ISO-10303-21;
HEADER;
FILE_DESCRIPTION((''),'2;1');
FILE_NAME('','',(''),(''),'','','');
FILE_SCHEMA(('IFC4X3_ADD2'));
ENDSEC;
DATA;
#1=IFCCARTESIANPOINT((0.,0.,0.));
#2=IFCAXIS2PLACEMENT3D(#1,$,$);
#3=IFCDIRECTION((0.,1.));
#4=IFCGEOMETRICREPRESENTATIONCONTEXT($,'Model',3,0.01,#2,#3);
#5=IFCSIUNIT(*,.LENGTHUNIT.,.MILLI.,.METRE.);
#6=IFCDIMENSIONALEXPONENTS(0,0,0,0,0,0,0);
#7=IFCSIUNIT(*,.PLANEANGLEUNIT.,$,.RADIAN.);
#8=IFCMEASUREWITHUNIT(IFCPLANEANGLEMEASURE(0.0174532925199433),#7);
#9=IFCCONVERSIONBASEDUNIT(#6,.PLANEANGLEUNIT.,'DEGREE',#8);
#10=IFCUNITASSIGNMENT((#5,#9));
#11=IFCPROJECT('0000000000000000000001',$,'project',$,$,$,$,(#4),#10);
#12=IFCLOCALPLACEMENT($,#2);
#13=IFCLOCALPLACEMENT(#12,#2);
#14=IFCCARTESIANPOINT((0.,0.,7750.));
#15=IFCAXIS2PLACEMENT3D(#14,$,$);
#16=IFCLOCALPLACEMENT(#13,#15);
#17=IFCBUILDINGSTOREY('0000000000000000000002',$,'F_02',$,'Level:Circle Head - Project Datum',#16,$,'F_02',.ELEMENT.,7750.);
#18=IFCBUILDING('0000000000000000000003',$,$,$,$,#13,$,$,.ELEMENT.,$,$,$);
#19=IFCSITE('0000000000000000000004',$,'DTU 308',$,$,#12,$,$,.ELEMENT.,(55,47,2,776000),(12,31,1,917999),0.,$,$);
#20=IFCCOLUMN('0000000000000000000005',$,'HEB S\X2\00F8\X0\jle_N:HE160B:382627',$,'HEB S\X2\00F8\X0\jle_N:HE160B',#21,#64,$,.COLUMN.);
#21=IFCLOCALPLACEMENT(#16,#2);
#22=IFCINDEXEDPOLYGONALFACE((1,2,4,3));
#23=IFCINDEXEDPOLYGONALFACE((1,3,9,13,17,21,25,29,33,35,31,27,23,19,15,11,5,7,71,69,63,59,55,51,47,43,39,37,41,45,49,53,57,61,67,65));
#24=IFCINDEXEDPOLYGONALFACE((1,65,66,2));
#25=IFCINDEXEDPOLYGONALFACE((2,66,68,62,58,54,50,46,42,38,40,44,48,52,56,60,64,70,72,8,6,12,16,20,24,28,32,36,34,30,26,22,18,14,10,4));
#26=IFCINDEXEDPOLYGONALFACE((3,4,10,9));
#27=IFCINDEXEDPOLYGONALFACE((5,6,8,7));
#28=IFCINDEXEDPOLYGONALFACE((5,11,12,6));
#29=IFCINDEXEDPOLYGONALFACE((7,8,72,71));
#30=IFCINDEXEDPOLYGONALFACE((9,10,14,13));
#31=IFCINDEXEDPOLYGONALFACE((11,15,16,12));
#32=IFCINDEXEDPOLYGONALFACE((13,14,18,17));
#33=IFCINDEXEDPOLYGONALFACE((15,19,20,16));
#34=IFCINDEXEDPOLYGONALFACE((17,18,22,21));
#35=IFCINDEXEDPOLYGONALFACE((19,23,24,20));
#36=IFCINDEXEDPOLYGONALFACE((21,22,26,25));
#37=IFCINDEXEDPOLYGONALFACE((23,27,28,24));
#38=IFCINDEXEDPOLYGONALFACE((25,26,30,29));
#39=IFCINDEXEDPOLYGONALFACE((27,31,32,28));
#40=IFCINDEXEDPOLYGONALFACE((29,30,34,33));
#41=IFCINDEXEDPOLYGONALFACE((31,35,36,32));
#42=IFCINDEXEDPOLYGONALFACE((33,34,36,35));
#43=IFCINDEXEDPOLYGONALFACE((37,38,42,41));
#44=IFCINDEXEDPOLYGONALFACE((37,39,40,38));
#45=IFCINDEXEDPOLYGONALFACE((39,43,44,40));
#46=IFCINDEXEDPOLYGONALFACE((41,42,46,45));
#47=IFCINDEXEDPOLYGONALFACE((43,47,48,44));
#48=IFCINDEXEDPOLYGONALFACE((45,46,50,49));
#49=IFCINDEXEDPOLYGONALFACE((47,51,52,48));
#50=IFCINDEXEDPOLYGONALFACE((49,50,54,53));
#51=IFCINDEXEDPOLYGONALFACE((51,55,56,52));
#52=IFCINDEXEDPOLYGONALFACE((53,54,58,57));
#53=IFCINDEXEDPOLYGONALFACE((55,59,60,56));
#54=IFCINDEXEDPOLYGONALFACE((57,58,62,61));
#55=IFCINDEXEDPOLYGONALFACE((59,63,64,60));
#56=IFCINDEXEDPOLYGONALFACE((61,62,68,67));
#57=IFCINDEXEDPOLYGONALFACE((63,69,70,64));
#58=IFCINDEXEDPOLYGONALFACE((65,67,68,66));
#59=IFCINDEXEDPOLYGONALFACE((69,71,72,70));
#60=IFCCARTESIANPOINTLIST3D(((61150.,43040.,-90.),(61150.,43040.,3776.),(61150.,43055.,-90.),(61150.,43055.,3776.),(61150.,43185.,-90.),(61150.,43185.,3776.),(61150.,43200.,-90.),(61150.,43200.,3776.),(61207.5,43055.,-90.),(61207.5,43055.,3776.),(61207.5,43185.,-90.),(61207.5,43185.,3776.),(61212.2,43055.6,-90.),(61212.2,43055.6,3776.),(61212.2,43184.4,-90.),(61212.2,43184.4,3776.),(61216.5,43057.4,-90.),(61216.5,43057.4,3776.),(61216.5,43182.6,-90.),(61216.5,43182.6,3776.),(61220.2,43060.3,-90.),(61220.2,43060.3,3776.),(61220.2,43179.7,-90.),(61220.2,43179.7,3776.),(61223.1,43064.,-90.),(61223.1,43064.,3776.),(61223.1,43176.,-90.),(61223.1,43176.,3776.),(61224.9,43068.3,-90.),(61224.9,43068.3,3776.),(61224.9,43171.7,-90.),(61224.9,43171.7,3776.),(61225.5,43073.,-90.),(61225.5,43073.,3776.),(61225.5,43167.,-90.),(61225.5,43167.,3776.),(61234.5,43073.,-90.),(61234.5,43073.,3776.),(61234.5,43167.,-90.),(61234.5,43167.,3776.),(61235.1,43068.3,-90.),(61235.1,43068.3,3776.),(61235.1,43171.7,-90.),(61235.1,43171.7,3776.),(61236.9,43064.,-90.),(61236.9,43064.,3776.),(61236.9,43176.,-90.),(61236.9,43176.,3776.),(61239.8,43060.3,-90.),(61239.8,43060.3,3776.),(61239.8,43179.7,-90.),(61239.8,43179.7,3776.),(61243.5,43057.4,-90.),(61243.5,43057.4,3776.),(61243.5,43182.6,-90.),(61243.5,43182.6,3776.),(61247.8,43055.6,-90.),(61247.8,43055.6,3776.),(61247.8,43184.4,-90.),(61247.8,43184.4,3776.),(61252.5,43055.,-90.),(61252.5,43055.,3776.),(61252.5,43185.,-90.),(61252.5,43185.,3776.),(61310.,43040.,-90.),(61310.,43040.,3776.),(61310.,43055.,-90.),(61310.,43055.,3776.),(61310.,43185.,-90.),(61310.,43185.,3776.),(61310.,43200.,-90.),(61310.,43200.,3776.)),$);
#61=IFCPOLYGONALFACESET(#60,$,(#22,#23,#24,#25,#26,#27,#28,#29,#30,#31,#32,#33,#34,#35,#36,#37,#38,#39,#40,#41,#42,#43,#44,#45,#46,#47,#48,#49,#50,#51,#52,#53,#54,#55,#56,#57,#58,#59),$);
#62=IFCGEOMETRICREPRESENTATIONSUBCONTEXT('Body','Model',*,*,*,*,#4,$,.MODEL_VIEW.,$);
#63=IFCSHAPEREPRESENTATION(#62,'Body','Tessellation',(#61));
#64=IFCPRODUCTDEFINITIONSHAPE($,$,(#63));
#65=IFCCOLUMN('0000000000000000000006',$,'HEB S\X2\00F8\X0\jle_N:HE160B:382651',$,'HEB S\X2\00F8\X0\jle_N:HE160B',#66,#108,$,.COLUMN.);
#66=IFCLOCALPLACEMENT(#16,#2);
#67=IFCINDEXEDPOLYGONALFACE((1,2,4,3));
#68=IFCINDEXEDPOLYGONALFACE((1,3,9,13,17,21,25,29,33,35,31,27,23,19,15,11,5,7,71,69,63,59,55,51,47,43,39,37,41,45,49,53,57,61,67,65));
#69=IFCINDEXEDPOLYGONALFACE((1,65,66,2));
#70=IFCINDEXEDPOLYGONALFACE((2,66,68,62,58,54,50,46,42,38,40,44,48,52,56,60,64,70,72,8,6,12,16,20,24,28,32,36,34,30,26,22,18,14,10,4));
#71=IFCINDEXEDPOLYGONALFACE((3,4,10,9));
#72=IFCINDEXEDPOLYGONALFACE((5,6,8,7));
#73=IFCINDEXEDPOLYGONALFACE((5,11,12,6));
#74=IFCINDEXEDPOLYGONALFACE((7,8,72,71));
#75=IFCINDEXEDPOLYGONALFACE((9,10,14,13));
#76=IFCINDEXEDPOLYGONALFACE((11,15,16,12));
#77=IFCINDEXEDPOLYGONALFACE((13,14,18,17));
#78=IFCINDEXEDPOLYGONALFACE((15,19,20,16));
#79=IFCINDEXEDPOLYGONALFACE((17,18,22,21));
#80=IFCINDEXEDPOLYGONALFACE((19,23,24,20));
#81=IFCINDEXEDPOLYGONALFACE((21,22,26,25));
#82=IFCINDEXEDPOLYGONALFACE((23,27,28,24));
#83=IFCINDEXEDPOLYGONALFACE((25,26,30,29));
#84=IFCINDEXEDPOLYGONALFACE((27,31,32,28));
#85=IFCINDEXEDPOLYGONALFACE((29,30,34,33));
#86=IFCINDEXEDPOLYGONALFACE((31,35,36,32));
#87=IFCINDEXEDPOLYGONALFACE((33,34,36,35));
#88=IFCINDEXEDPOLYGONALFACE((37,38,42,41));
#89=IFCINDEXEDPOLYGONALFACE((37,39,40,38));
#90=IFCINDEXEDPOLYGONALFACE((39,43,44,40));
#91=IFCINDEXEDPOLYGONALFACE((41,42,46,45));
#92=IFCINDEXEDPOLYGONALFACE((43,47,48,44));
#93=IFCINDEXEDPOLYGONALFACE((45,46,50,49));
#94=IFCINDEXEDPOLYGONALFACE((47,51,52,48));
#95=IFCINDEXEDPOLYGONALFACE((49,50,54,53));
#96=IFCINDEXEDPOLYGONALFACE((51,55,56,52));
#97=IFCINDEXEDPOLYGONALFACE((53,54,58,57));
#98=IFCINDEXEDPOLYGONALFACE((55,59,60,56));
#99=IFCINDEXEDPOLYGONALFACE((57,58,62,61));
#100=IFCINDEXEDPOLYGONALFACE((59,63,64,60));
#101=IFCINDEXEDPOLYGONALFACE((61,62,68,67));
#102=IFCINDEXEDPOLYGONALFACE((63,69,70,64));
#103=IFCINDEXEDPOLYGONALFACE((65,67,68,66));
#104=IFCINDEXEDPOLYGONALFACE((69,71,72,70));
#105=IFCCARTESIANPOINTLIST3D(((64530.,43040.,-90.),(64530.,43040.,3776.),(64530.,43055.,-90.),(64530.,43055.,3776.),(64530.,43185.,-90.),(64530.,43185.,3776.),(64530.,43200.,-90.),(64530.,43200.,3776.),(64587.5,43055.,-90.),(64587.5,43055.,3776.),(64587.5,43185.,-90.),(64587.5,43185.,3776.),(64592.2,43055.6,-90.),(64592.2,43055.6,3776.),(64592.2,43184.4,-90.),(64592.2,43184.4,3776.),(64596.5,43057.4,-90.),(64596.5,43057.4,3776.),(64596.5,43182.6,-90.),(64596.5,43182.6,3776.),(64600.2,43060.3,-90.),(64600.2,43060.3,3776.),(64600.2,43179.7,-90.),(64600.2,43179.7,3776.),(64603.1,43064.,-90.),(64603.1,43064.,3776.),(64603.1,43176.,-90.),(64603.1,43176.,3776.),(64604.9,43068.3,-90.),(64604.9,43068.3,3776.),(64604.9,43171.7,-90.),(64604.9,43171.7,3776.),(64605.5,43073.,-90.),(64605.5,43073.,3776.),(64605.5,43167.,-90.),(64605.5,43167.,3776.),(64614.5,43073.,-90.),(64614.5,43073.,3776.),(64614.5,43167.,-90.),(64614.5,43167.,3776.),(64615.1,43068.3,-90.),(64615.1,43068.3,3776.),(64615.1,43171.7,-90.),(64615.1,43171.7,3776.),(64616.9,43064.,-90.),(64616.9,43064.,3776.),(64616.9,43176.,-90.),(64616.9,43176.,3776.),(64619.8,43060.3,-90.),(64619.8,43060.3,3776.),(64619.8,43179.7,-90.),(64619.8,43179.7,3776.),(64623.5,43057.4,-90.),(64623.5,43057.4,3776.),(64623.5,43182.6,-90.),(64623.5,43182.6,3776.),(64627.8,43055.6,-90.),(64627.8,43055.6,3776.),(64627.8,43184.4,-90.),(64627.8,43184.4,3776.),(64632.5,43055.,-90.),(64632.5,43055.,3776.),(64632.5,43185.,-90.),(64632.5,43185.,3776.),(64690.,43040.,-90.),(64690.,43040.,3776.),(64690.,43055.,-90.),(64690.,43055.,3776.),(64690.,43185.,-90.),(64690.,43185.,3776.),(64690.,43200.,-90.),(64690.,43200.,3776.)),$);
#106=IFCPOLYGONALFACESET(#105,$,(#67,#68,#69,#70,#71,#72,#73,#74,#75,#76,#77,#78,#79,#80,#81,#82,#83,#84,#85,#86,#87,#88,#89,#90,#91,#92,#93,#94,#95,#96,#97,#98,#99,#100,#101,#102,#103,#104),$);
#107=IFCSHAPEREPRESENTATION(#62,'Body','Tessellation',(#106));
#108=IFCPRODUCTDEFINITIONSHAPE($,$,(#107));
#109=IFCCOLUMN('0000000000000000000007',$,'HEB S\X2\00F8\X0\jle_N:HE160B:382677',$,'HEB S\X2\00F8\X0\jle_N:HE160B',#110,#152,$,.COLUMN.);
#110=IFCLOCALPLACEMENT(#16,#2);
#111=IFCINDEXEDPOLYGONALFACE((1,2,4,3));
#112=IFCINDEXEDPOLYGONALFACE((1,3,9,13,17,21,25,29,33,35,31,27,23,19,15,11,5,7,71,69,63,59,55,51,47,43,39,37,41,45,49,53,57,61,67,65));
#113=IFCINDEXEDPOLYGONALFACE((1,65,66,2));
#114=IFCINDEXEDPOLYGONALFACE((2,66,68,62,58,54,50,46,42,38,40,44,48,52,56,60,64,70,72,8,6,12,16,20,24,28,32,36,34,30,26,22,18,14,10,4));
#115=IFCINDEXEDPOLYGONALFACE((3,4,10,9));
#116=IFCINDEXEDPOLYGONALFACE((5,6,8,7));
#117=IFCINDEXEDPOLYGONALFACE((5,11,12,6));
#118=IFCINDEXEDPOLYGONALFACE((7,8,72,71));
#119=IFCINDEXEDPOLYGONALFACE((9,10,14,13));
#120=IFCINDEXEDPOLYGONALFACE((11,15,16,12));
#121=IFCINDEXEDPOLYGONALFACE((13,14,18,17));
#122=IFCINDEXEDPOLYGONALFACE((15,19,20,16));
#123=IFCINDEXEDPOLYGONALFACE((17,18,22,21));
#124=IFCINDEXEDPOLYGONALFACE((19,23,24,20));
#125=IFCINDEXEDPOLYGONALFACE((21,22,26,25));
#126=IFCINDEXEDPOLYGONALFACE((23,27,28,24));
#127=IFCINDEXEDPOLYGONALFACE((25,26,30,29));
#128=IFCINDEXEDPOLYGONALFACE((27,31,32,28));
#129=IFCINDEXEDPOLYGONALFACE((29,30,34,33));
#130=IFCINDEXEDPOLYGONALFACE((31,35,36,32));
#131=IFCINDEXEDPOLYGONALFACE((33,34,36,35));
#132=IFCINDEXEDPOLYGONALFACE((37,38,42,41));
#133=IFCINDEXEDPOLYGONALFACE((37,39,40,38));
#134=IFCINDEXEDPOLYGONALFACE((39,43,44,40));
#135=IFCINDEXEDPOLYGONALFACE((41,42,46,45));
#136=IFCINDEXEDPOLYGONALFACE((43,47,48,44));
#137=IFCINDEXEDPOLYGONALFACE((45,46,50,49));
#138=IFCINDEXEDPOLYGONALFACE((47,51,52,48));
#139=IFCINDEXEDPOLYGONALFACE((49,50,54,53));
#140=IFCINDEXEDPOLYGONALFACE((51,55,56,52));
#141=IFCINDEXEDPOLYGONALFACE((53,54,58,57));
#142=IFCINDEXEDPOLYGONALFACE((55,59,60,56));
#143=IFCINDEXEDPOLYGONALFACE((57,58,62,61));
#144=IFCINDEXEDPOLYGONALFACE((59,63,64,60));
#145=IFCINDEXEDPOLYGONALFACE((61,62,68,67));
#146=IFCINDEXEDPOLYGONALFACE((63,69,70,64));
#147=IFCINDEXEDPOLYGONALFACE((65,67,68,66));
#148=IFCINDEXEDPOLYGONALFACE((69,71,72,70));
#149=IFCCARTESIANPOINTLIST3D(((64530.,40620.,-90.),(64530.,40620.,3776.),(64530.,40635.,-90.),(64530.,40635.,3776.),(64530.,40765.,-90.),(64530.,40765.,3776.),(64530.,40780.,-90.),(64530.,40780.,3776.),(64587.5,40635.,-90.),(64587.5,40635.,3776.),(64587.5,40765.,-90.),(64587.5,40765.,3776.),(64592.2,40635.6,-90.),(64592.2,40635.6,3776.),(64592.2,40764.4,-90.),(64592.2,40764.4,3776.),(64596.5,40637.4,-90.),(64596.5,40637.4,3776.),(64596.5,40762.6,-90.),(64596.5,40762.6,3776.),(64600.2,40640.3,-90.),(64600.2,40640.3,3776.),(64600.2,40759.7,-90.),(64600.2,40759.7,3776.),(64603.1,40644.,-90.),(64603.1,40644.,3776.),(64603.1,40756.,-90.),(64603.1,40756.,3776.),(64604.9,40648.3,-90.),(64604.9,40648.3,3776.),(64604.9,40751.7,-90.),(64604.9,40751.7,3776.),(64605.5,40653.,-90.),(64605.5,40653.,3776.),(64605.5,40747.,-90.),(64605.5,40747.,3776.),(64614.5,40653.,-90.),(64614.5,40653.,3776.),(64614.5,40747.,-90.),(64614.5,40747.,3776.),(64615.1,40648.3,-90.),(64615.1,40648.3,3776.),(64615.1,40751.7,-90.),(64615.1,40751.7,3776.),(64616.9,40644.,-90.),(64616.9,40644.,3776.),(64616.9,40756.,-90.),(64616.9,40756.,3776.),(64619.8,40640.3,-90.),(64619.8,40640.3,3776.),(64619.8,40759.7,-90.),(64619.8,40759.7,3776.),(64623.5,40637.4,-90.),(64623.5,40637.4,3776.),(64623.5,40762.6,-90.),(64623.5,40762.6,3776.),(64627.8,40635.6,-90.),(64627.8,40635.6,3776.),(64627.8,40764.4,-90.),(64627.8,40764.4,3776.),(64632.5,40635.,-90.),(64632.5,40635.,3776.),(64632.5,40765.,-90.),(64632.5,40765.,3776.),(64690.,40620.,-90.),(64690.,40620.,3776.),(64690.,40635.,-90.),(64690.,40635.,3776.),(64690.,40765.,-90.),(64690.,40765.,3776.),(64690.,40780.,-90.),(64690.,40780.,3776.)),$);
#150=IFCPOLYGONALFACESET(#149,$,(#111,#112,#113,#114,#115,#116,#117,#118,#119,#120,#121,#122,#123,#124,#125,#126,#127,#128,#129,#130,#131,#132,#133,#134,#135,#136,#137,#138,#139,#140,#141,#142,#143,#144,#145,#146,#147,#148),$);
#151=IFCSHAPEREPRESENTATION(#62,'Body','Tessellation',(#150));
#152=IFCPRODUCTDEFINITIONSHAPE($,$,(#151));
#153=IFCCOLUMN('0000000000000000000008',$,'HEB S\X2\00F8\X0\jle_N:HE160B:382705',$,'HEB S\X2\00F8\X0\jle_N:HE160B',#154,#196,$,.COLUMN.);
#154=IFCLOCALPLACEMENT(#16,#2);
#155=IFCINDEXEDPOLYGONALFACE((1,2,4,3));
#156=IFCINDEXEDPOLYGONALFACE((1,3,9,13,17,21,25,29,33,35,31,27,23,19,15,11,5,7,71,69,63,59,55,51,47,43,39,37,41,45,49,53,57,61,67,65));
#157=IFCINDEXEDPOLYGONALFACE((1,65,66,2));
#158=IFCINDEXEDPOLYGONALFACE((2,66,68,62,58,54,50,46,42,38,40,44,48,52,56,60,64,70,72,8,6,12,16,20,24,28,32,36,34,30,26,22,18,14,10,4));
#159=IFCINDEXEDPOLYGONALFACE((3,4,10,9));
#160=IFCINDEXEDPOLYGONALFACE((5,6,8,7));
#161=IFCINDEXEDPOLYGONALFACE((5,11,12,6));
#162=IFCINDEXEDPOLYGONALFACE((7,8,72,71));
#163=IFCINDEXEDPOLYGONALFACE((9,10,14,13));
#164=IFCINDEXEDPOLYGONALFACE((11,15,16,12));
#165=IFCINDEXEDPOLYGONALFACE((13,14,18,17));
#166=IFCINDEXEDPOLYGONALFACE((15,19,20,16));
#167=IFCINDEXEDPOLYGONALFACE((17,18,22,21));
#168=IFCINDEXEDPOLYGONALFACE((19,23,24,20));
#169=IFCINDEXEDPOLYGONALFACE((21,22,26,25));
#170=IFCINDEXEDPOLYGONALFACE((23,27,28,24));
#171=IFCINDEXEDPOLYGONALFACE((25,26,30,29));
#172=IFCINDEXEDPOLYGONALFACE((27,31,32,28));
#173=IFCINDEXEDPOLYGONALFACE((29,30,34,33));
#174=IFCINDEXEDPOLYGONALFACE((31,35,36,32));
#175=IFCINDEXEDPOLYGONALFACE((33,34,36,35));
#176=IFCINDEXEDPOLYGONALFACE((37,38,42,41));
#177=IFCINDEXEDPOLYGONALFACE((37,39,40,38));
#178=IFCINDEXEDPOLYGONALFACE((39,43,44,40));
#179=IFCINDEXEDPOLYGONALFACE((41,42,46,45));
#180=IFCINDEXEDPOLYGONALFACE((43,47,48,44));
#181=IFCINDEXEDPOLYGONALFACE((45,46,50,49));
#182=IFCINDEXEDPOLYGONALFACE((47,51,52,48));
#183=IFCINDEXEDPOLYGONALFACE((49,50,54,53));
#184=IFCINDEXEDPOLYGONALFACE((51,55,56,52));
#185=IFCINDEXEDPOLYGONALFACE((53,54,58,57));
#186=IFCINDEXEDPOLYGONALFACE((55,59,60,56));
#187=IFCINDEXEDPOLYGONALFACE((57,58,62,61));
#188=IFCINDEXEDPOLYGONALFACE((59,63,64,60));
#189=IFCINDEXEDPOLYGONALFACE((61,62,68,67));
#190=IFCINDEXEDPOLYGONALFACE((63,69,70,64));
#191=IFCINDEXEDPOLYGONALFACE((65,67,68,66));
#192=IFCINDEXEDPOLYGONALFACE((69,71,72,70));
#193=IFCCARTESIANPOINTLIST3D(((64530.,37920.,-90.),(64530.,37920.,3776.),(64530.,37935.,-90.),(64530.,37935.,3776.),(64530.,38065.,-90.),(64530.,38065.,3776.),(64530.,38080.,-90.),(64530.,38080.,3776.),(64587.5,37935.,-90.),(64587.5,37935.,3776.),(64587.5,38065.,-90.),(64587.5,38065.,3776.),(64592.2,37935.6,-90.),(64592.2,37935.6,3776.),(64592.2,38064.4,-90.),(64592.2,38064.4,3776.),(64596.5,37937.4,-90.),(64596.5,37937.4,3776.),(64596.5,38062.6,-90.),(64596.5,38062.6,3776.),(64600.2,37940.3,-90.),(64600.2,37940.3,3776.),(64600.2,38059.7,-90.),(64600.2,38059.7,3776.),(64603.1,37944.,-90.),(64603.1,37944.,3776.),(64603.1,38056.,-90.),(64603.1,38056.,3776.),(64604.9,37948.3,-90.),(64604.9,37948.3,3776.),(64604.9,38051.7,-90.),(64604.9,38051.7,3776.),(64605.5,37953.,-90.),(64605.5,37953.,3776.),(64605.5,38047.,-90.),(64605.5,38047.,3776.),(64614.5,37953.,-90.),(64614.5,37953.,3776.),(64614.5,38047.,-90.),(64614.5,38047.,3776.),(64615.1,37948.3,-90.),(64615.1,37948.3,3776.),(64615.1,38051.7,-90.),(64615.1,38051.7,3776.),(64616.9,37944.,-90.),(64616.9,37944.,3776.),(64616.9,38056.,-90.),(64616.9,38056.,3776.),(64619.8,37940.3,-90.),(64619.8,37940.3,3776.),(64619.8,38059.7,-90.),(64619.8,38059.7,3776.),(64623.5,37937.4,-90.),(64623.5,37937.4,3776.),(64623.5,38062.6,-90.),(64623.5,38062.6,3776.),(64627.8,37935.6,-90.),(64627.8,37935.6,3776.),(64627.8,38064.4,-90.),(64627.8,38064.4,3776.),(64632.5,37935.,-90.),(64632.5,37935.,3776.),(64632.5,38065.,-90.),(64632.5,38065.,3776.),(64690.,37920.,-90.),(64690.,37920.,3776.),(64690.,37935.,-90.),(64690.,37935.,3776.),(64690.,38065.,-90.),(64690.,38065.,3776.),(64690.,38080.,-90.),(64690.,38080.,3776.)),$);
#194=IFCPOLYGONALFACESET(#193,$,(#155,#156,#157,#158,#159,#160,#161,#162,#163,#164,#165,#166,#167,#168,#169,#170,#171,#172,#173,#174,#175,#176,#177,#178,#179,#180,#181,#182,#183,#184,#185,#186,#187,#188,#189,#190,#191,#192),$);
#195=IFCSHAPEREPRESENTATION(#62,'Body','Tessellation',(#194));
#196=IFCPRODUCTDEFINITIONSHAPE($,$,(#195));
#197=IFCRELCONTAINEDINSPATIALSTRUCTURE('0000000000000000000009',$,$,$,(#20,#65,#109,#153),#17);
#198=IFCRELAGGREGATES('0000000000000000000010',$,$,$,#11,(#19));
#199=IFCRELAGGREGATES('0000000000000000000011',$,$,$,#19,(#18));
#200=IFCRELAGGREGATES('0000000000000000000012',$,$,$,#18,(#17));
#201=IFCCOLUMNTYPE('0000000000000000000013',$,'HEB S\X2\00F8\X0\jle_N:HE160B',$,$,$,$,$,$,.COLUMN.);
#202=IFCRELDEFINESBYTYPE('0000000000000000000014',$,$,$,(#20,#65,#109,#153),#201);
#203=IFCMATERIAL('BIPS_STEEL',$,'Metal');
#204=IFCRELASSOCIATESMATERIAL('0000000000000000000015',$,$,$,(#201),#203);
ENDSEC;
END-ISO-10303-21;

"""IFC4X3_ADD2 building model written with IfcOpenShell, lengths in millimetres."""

from ifc_helpers import new_model, entity, si_unit, converted_unit, direction, frame, frame_2d, origin, place, context, subcontext, project, spatial, i_section, extrude, source, transform, mapped, material, material_profile, profile_set, type_object, element, save


model = new_model("IFC4X3_ADD2")

# Units and contexts
model_context = context("Model", 3, precision=0.01, world=origin(), true_north=direction((0.0, 1.0)))
body_context = subcontext(model_context, "Body", "Model", "MODEL_VIEW")
ifc_project = project(units=[si_unit("LENGTHUNIT", "METRE", prefix="MILLI"), converted_unit("PLANEANGLEUNIT", "DEGREE", entity("IfcPlaneAngleMeasure", 0.0174532925199433), si_unit("PLANEANGLEUNIT", "RADIAN"), dimensions=[0, 0, 0, 0, 0, 0, 0])], contexts=[model_context])

# Site, building, storey
site_placement = place(None, origin())
site = spatial("IfcSite", under=ifc_project, at=site_placement, Name="DTU 308", CompositionType="ELEMENT", RefLatitude=(55, 47, 2, 776000), RefLongitude=(12, 31, 1, 917999), RefElevation=0.0)
building_placement = place(site_placement, origin())
building = spatial("IfcBuilding", under=site, at=building_placement, CompositionType="ELEMENT")
storey_placement = place(building_placement, frame((0.0, 0.0, 7750.0)))
storey = spatial("IfcBuildingStorey", under=building, at=storey_placement, Name="F_02", ObjectType="Level:Circle Head - Project Datum", LongName="F_02", CompositionType="ELEMENT", Elevation=7750.0)

# Columns
ifc_material = material(Name="BIPS_STEEL", Category="Metal")
ifc_material_profile_1 = material_profile(ifc_material, i_section(OverallWidth=160.0, OverallDepth=160.0, WebThickness=9.0, FlangeThickness=15.0, FilletRadius=18.0, at=frame_2d((0.0, 0.0), x_axis=(1.0, 0.0))), Name="HE160B")
ifc_profile_set_1 = profile_set([ifc_material_profile_1], Name="HE160B")
column_type_1 = type_object("IfcColumnType", Name="HEB Søjle_N:HE160B", PredefinedType="COLUMN", material=ifc_profile_set_1)
shared_shape_1 = source(origin(), body_context, "Body", "SweptSolid", [
    extrude(i_section(OverallWidth=160.0, OverallDepth=160.0, WebThickness=9.0, FlangeThickness=15.0, FilletRadius=18.0, at=frame_2d((0.0, 0.0), x_axis=(1.0, 0.0))), frame((0.0, 0.0, 7660.0), z_axis=(0.0, 0.0, 1.0), x_axis=(-1.0, 0.0, 0.0)), (0.0, 0.0, 1.0), 3866.0),
])
for number, where, name in (
    (1, (61230.0, 43120.0, -7750.0), "HEB Søjle_N:HE160B:382627"),
    (2, (64610.0, 43120.0, -7750.0), "HEB Søjle_N:HE160B:382651"),
    (3, (64610.0, 40700.0, -7750.0), "HEB Søjle_N:HE160B:382677"),
    (4, (64610.0, 38000.0, -7750.0), "HEB Søjle_N:HE160B:382705"),
):
    element("IfcColumn", number, at=place(storey_placement, frame(where)), inside=storey, type_object=column_type_1, Name=name, ObjectType="HEB Søjle_N:HE160B", PredefinedType="COLUMN", context=body_context, shape_type="MappedRepresentation", body=[
        mapped(shared_shape_1, transform((0.0, 0.0, 0.0), scale=1.0)),
    ])

save(model, "model.ifc")
